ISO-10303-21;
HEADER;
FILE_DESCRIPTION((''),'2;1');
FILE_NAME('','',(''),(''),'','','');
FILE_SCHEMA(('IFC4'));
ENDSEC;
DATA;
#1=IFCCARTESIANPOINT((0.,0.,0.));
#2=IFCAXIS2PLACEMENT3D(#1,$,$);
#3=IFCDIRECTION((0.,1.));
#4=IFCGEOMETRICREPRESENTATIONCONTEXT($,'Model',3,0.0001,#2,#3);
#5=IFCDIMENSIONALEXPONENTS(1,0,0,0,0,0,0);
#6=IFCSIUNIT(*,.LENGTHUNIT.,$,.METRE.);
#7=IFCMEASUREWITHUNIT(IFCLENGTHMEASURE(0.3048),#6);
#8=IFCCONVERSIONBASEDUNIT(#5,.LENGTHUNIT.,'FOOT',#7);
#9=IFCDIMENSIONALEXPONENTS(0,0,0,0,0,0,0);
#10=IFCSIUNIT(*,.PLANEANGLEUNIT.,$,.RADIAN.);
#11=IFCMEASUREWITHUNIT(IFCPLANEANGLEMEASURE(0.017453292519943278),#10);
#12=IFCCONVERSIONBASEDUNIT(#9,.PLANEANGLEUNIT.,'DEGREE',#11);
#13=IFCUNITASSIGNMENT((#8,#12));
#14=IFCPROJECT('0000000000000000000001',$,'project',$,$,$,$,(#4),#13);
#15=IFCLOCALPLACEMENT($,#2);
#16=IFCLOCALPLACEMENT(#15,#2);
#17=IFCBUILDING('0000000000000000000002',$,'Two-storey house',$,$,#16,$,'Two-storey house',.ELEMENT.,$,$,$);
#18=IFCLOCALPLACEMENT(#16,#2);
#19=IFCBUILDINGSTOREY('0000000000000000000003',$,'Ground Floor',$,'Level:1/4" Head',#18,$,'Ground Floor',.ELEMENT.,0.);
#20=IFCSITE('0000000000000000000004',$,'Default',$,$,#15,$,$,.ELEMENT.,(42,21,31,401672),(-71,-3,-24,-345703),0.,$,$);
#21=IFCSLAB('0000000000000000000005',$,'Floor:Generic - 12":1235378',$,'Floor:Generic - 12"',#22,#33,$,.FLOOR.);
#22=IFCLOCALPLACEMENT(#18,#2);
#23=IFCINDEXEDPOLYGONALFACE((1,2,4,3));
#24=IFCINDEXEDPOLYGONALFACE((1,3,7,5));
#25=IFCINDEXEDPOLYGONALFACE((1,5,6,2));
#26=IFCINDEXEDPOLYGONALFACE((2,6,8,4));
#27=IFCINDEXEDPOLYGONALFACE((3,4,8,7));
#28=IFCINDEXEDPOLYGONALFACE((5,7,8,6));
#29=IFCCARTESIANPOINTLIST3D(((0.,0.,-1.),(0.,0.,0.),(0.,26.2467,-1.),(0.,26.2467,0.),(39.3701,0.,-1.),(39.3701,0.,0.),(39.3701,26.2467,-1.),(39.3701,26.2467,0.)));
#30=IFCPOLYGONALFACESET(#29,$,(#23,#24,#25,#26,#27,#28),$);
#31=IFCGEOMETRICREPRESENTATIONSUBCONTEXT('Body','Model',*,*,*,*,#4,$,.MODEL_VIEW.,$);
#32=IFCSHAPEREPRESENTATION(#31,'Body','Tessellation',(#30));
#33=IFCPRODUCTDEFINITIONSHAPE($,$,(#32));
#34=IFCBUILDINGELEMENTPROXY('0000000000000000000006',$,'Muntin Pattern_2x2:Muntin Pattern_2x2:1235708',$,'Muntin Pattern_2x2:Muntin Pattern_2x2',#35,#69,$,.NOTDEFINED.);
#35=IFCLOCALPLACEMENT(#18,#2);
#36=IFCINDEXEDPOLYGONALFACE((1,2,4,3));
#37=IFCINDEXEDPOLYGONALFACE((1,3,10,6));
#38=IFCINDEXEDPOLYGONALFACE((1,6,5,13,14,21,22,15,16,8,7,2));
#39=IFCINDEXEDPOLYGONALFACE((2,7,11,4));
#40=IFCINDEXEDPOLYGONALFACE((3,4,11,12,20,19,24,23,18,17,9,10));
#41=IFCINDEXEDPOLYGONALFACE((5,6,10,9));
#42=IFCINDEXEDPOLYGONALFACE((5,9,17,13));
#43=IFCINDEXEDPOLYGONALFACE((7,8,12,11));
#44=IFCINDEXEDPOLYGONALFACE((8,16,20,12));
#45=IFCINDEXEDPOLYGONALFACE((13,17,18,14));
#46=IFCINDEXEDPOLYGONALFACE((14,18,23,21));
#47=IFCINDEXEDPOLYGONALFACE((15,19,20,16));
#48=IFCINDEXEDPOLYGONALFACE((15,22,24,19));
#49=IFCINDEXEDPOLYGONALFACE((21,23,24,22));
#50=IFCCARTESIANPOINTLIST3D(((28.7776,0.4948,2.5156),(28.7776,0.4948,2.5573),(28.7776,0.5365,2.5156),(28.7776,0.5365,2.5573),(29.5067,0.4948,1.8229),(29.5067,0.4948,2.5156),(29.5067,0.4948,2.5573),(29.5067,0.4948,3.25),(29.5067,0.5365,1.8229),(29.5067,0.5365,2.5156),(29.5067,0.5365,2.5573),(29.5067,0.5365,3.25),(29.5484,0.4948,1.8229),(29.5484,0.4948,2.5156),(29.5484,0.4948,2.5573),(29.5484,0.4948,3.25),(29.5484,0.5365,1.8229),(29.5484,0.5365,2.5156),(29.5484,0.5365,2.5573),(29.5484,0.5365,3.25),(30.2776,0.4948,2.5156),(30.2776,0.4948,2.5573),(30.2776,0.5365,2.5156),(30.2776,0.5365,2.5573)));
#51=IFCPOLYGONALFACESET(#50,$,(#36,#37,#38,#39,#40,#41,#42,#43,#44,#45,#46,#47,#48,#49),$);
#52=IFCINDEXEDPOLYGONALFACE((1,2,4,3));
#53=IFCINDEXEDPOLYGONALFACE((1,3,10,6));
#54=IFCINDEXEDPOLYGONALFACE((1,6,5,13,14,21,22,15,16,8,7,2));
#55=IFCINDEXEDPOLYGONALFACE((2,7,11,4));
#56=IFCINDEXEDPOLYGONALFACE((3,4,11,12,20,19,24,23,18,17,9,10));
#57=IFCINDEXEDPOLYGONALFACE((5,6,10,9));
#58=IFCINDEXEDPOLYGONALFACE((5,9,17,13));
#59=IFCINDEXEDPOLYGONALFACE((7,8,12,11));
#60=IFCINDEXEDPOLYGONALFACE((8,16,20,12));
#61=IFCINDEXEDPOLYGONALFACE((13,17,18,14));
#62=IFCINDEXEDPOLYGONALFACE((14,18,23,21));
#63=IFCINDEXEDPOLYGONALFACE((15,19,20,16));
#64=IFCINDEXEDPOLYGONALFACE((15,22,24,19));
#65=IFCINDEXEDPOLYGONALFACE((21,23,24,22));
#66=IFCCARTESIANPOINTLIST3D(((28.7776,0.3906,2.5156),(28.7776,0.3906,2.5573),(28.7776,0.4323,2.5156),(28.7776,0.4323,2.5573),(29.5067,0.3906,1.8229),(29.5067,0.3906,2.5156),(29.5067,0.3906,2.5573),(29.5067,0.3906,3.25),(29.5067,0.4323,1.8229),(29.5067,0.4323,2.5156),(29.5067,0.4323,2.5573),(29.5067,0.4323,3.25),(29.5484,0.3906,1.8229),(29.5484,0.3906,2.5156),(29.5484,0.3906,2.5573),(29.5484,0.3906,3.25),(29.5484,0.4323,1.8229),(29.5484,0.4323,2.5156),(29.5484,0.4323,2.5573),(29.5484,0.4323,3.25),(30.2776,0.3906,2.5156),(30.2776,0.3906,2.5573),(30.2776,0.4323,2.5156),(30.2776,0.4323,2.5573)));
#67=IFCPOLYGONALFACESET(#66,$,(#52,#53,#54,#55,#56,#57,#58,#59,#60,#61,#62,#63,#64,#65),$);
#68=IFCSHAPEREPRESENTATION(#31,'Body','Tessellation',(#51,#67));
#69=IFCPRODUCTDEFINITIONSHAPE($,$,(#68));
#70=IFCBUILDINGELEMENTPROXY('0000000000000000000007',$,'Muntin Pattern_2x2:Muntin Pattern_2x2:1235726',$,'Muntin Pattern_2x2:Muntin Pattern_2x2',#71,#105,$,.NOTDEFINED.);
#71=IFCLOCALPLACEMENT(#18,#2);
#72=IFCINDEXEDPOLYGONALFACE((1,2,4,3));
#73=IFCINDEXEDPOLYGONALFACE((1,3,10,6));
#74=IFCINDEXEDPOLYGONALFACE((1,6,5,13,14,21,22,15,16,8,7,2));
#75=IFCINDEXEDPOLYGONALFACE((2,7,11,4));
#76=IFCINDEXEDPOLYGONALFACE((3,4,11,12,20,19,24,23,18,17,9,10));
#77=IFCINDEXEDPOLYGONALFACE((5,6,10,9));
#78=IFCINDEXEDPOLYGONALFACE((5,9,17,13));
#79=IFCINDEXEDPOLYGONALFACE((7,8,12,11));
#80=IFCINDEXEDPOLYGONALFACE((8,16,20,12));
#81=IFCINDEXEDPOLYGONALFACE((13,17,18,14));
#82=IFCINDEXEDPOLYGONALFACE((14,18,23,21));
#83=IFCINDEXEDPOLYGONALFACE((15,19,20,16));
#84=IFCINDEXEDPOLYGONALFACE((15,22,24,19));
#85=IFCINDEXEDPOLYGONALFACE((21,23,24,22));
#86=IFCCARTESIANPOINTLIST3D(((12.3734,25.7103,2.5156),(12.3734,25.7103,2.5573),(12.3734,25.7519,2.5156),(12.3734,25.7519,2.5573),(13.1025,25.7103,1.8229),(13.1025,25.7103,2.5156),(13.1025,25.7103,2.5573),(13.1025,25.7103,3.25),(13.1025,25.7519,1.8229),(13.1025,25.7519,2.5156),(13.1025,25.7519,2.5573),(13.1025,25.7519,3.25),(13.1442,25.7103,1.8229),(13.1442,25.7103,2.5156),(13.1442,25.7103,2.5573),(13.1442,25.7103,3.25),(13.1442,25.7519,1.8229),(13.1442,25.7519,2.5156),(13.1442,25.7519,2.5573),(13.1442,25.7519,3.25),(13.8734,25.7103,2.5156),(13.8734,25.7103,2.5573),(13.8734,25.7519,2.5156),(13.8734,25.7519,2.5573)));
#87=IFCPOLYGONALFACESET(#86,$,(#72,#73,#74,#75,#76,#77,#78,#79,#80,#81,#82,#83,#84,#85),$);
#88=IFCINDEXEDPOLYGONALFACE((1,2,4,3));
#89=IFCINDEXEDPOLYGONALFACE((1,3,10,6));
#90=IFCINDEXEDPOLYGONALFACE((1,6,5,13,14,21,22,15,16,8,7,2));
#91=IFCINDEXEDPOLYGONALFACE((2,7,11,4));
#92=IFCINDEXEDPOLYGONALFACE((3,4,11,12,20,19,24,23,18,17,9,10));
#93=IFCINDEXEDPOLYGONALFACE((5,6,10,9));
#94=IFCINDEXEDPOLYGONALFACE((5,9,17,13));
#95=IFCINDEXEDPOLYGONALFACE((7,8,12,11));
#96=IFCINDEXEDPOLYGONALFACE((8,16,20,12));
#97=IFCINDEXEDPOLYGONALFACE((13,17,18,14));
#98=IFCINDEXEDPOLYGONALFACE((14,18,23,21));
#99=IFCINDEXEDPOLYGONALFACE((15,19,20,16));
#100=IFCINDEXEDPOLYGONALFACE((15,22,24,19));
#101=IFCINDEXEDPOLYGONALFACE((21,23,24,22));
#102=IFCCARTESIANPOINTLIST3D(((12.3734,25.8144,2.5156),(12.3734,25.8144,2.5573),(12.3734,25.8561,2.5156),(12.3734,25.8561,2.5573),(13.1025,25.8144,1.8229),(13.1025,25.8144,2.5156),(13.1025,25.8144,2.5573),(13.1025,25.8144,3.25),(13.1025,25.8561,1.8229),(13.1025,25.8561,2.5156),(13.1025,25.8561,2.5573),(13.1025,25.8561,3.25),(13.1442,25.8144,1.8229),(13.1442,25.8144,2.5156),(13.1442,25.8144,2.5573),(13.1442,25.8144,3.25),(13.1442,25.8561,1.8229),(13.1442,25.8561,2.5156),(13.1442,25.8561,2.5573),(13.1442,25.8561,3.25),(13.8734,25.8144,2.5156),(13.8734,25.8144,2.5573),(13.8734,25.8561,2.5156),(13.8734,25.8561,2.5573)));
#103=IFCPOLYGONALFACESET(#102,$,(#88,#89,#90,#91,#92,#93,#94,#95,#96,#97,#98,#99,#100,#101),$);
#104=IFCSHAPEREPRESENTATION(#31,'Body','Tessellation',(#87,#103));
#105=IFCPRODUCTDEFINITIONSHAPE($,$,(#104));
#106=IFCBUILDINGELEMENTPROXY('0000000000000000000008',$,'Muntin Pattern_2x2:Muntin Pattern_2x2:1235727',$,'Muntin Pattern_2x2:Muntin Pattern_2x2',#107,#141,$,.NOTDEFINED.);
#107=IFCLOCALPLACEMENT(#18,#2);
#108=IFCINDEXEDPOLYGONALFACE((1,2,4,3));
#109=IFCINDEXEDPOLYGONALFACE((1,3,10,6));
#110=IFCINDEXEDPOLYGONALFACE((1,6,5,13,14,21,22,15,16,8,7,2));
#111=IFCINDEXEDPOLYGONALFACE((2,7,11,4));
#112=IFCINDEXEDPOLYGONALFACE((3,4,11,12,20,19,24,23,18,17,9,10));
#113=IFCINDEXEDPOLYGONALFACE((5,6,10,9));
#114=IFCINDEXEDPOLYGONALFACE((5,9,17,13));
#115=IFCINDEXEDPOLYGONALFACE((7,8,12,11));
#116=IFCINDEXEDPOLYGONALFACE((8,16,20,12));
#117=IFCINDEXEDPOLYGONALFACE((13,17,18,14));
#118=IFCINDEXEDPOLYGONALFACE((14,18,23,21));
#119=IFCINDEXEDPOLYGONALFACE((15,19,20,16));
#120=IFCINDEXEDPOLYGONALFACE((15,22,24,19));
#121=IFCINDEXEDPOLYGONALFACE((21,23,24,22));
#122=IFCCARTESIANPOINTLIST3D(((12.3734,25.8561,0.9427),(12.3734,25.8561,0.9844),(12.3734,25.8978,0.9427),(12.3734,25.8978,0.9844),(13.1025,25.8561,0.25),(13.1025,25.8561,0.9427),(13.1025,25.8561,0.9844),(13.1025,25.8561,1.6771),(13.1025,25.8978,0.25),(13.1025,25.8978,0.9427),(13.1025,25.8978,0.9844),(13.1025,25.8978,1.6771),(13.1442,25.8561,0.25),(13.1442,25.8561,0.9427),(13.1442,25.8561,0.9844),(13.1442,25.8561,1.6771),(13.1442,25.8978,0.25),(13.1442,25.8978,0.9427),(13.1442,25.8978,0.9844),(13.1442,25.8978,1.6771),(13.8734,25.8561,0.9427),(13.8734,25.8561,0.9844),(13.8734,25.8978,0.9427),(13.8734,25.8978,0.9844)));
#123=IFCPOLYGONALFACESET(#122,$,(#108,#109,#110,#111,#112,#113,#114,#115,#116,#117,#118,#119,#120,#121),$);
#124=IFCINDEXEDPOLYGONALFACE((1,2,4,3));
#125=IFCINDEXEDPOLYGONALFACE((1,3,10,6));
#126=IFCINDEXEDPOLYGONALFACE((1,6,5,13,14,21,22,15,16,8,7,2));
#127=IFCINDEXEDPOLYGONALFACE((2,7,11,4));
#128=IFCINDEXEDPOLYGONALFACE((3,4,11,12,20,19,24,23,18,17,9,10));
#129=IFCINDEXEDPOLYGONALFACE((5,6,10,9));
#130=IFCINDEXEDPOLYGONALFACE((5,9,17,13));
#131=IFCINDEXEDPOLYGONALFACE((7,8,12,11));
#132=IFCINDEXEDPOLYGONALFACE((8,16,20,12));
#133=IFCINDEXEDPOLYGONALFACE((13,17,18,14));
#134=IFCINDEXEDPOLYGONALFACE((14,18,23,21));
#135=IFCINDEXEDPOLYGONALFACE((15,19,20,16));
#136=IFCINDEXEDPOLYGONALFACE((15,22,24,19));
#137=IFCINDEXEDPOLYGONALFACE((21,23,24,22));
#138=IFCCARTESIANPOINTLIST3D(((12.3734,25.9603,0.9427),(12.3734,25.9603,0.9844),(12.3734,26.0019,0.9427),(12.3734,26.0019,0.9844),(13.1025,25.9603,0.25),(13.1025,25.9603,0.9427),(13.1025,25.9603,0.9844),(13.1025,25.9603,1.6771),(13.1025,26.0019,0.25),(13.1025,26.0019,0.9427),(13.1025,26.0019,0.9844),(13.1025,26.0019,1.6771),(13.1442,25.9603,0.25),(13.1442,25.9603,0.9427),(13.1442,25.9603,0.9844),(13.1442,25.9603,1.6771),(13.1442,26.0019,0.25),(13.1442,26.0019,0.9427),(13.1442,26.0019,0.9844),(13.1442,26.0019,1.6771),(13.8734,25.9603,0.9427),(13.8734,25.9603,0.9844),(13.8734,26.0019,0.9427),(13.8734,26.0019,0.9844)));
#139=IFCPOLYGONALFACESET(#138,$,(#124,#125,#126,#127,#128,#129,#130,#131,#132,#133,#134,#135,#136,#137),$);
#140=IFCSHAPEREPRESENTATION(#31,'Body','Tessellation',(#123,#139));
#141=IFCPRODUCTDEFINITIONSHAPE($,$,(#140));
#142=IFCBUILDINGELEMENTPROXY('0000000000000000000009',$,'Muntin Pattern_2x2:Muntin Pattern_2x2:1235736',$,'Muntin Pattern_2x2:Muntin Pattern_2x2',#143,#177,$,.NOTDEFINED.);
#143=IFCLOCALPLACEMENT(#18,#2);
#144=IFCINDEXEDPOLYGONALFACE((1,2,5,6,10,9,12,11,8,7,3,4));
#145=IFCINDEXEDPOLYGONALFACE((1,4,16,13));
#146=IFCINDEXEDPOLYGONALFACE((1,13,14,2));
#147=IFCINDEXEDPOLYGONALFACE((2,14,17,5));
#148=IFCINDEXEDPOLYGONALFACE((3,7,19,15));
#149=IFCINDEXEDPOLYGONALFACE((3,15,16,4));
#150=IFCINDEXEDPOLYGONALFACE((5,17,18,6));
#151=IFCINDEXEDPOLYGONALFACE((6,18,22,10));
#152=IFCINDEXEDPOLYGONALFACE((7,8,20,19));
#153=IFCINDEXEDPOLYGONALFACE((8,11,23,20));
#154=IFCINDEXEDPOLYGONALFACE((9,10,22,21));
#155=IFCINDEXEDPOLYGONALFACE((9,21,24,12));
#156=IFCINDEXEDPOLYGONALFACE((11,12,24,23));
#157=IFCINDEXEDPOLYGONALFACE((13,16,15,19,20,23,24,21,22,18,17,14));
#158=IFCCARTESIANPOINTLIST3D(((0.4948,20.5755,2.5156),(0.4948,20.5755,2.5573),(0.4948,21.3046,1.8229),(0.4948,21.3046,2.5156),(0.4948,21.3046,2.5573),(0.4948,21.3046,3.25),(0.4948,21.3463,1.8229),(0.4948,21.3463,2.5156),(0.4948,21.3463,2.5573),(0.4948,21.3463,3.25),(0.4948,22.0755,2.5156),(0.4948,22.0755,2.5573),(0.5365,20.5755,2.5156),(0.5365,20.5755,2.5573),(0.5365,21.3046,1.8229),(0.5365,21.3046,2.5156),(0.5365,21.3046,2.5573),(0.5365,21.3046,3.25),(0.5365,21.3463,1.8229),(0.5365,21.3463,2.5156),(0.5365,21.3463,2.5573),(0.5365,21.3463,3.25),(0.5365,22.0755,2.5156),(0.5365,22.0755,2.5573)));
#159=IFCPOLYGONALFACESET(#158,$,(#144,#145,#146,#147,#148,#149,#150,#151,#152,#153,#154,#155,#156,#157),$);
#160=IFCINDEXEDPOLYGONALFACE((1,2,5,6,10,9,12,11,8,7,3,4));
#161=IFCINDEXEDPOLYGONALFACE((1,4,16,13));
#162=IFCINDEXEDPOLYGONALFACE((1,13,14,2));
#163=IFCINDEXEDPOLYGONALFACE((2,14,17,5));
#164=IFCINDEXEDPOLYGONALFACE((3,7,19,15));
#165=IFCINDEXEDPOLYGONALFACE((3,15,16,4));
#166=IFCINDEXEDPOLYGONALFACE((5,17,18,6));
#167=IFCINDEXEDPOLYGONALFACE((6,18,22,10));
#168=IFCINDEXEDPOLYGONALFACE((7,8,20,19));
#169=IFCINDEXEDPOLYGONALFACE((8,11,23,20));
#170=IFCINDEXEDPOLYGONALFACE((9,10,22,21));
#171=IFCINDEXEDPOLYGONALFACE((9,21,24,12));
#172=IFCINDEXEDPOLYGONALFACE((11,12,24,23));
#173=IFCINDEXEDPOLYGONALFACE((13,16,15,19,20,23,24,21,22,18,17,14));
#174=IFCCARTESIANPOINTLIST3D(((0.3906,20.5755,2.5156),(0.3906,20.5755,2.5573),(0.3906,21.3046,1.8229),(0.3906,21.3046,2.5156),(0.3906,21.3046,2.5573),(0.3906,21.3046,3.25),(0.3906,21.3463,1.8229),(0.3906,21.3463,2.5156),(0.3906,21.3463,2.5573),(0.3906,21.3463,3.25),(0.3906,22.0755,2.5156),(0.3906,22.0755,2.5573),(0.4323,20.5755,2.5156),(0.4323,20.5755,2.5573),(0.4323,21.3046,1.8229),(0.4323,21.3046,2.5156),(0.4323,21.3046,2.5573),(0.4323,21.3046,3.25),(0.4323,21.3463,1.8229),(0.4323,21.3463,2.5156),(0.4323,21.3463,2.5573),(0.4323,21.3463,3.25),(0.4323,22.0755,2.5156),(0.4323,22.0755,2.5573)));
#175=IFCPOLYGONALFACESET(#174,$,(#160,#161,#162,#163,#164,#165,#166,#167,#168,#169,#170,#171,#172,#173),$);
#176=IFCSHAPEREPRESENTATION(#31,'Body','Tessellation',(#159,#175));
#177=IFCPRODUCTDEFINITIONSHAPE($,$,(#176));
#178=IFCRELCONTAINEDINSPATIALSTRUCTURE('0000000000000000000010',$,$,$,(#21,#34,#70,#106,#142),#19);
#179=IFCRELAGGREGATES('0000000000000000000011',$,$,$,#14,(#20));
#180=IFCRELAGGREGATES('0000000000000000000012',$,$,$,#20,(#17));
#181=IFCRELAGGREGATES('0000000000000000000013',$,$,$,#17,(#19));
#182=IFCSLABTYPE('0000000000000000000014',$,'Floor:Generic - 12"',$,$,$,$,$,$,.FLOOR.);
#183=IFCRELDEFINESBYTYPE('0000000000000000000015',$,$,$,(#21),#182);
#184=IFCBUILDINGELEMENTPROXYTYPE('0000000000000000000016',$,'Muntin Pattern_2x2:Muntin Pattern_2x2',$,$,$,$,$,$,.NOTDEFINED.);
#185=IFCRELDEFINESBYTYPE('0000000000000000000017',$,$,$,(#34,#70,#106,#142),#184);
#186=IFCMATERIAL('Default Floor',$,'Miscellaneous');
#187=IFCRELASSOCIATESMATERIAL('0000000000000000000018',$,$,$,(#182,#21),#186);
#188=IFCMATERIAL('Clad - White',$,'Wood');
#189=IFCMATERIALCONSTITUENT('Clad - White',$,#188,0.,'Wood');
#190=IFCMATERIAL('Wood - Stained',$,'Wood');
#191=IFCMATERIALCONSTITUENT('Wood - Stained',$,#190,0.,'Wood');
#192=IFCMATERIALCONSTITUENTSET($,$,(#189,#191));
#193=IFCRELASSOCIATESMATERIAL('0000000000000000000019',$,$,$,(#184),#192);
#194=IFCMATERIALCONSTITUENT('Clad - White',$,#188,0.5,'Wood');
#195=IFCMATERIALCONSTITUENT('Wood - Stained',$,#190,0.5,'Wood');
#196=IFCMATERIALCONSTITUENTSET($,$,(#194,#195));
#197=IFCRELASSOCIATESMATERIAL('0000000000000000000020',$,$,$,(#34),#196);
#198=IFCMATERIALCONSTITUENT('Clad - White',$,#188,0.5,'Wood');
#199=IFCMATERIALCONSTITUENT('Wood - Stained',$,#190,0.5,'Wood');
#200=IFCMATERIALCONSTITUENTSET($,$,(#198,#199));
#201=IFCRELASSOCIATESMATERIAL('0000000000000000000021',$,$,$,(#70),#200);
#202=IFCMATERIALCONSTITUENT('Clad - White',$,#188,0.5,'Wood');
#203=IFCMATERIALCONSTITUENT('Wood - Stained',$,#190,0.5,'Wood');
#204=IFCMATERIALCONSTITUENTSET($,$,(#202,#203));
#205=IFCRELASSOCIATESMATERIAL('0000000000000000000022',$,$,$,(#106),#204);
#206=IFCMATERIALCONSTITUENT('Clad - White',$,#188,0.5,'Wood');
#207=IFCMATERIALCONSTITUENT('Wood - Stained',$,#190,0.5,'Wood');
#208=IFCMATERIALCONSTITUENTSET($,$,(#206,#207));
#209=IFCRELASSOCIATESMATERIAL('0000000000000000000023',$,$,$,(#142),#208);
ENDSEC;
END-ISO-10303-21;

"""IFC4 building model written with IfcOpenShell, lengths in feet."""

from ifc_helpers import new_model, entity, si_unit, converted_unit, direction, frame, origin, place, context, subcontext, project, spatial, indexed_curve, outline, extrude, source, transform, mapped, material, constituent, constituent_set, type_object, type_shapes, element, save


model = new_model("IFC4")

# Units and contexts
model_context = context("Model", 3, precision=0.0001, world=origin(), true_north=direction((0.0, 1.0)))
body_context = subcontext(model_context, "Body", "Model", "MODEL_VIEW")
ifc_project = project(units=[converted_unit("LENGTHUNIT", "FOOT", entity("IfcLengthMeasure", 0.3048), si_unit("LENGTHUNIT", "METRE"), dimensions=[1, 0, 0, 0, 0, 0, 0]), converted_unit("PLANEANGLEUNIT", "DEGREE", entity("IfcPlaneAngleMeasure", 0.017453292519943278), si_unit("PLANEANGLEUNIT", "RADIAN"), dimensions=[0, 0, 0, 0, 0, 0, 0])], contexts=[model_context])

# Site, building, storey
site_placement = place(None, origin())
site = spatial("IfcSite", under=ifc_project, at=site_placement, Name="Default", CompositionType="ELEMENT", RefLatitude=(42, 21, 31, 401672), RefLongitude=(-71, -3, -24, -345703), RefElevation=0.0)
building_placement = place(site_placement, origin())
building = spatial("IfcBuilding", under=site, at=building_placement, Name="Two-storey house", LongName="Two-storey house", CompositionType="ELEMENT")
storey_placement = place(building_placement, origin())
storey = spatial("IfcBuildingStorey", under=building, at=storey_placement, Name="Ground Floor", ObjectType="Level:1/4\" Head", LongName="Ground Floor", CompositionType="ELEMENT", Elevation=0.0)

# Slab
ifc_material_1 = material(Name="Default Floor", Category="Miscellaneous")
slab_type = type_object("IfcSlabType", Name="Floor:Generic - 12\"", PredefinedType="FLOOR", material=ifc_material_1)
slab_placement = place(storey_placement, origin())
element("IfcSlab", 1, at=slab_placement, inside=storey, type_object=slab_type, material=ifc_material_1, Name="Floor:Generic - 12\":1235378", ObjectType="Floor:Generic - 12\"", PredefinedType="FLOOR", context=body_context, shape_type="SweptSolid", body=[
    extrude(outline(indexed_curve([(-13.1234, -19.685), (13.1234, -19.685), (13.1234, 19.685), (-13.1234, 19.685), (-13.1234, -19.685)], self_intersect=False)), frame((19.685, 13.1234, 0.0), z_axis=(0.0, 0.0, -1.0), x_axis=(0.0, 1.0, 0.0)), (0.0, 0.0, 1.0), 1.0),
])

# Shared definitions
ifc_material_2 = material(Name="Wood - Stained", Category="Wood")

# Building element proxies
ifc_material_3 = material(Name="Clad - White", Category="Wood")
ifc_constituent_1 = constituent(ifc_material_3, Name="Clad - White", Category="Wood", fraction=0.5)
ifc_constituent_2 = constituent(ifc_material_2, Name="Wood - Stained", Category="Wood", fraction=0.5)
ifc_constituent_set_1 = constituent_set(constituents=[ifc_constituent_1, ifc_constituent_2])
ifc_constituent_3 = constituent(ifc_material_3, Name="Clad - White", Category="Wood", fraction=0.0)
ifc_constituent_4 = constituent(ifc_material_2, Name="Wood - Stained", Category="Wood", fraction=0.0)
ifc_constituent_set_2 = constituent_set(constituents=[ifc_constituent_3, ifc_constituent_4])
building_element_proxy_type_1 = type_object("IfcBuildingElementProxyType", Name="Muntin Pattern_2x2:Muntin Pattern_2x2", PredefinedType="NOTDEFINED", material=ifc_constituent_set_2)
shared_shape_1 = source(origin(), body_context, "Body", "SweptSolid", [
    extrude(outline(indexed_curve([(0.0208, -0.0208), (0.7135, -0.0208), (0.7135, 0.0208), (0.0208, 0.0208), (0.0208, 0.75), (-0.0208, 0.75), (-0.0208, 0.0208), (-0.7135, 0.0208), (-0.7135, -0.0208), (-0.0208, -0.0208), (-0.0208, -0.75), (0.0208, -0.75), (0.0208, -0.0208)], self_intersect=False)), frame((0.0, 0.0312, 0.7135), z_axis=(0.0, 1.0, 0.0), x_axis=(0.0, 0.0, 1.0)), (0.0, 0.0, 1.0), 0.0417),
    extrude(outline(indexed_curve([(0.0208, -0.0208), (0.7135, -0.0208), (0.7135, 0.0208), (0.0208, 0.0208), (0.0208, 0.75), (-0.0208, 0.75), (-0.0208, 0.0208), (-0.7135, 0.0208), (-0.7135, -0.0208), (-0.0208, -0.0208), (-0.0208, -0.75), (0.0208, -0.75), (0.0208, -0.0208)], self_intersect=False)), frame((0.0, -0.0729, 0.7135), z_axis=(0.0, 1.0, 0.0), x_axis=(0.0, 0.0, 1.0)), (0.0, 0.0, 1.0), 0.0417),
])
type_shapes(building_element_proxy_type_1, [shared_shape_1])
proxy_1_placement = place(storey_placement, frame((29.5276, 0.4635, 1.8229)))
element("IfcBuildingElementProxy", 2, at=proxy_1_placement, inside=storey, type_object=building_element_proxy_type_1, material=ifc_constituent_set_1, Name="Muntin Pattern_2x2:Muntin Pattern_2x2:1235708", ObjectType="Muntin Pattern_2x2:Muntin Pattern_2x2", PredefinedType="NOTDEFINED", context=body_context, shape_type="MappedRepresentation", body=[
    mapped(shared_shape_1, transform((0.0, 0.0, 0.0), scale=1.0)),
])
ifc_constituent_5 = constituent(ifc_material_3, Name="Clad - White", Category="Wood", fraction=0.5)
ifc_constituent_6 = constituent(ifc_material_2, Name="Wood - Stained", Category="Wood", fraction=0.5)
ifc_constituent_set_3 = constituent_set(constituents=[ifc_constituent_5, ifc_constituent_6])
proxy_2_placement = place(storey_placement, frame((13.1234, 25.7832, 1.8229), z_axis=(0.0, 0.0, 1.0), x_axis=(-1.0, 0.0, 0.0)))
element("IfcBuildingElementProxy", 3, at=proxy_2_placement, inside=storey, type_object=building_element_proxy_type_1, material=ifc_constituent_set_3, Name="Muntin Pattern_2x2:Muntin Pattern_2x2:1235726", ObjectType="Muntin Pattern_2x2:Muntin Pattern_2x2", PredefinedType="NOTDEFINED", context=body_context, shape_type="MappedRepresentation", body=[
    mapped(shared_shape_1, transform((0.0, 0.0, 0.0), scale=1.0)),
])
ifc_constituent_7 = constituent(ifc_material_3, Name="Clad - White", Category="Wood", fraction=0.5)
ifc_constituent_8 = constituent(ifc_material_2, Name="Wood - Stained", Category="Wood", fraction=0.5)
ifc_constituent_set_4 = constituent_set(constituents=[ifc_constituent_7, ifc_constituent_8])
proxy_3_placement = place(storey_placement, frame((13.1234, 25.929, 0.25), z_axis=(0.0, 0.0, 1.0), x_axis=(-1.0, 0.0, 0.0)))
element("IfcBuildingElementProxy", 4, at=proxy_3_placement, inside=storey, type_object=building_element_proxy_type_1, material=ifc_constituent_set_4, Name="Muntin Pattern_2x2:Muntin Pattern_2x2:1235727", ObjectType="Muntin Pattern_2x2:Muntin Pattern_2x2", PredefinedType="NOTDEFINED", context=body_context, shape_type="MappedRepresentation", body=[
    mapped(shared_shape_1, transform((0.0, 0.0, 0.0), scale=1.0)),
])
ifc_constituent_9 = constituent(ifc_material_3, Name="Clad - White", Category="Wood", fraction=0.5)
ifc_constituent_10 = constituent(ifc_material_2, Name="Wood - Stained", Category="Wood", fraction=0.5)
ifc_constituent_set_5 = constituent_set(constituents=[ifc_constituent_9, ifc_constituent_10])
proxy_4_placement = place(storey_placement, frame((0.4635, 21.3255, 1.8229), z_axis=(0.0, 0.0, 1.0), x_axis=(0.0, -1.0, 0.0)))
element("IfcBuildingElementProxy", 5, at=proxy_4_placement, inside=storey, type_object=building_element_proxy_type_1, material=ifc_constituent_set_5, Name="Muntin Pattern_2x2:Muntin Pattern_2x2:1235736", ObjectType="Muntin Pattern_2x2:Muntin Pattern_2x2", PredefinedType="NOTDEFINED", context=body_context, shape_type="MappedRepresentation", body=[
    mapped(shared_shape_1, transform((0.0, 0.0, 0.0), scale=1.0)),
])

save(model, "model.ifc")
